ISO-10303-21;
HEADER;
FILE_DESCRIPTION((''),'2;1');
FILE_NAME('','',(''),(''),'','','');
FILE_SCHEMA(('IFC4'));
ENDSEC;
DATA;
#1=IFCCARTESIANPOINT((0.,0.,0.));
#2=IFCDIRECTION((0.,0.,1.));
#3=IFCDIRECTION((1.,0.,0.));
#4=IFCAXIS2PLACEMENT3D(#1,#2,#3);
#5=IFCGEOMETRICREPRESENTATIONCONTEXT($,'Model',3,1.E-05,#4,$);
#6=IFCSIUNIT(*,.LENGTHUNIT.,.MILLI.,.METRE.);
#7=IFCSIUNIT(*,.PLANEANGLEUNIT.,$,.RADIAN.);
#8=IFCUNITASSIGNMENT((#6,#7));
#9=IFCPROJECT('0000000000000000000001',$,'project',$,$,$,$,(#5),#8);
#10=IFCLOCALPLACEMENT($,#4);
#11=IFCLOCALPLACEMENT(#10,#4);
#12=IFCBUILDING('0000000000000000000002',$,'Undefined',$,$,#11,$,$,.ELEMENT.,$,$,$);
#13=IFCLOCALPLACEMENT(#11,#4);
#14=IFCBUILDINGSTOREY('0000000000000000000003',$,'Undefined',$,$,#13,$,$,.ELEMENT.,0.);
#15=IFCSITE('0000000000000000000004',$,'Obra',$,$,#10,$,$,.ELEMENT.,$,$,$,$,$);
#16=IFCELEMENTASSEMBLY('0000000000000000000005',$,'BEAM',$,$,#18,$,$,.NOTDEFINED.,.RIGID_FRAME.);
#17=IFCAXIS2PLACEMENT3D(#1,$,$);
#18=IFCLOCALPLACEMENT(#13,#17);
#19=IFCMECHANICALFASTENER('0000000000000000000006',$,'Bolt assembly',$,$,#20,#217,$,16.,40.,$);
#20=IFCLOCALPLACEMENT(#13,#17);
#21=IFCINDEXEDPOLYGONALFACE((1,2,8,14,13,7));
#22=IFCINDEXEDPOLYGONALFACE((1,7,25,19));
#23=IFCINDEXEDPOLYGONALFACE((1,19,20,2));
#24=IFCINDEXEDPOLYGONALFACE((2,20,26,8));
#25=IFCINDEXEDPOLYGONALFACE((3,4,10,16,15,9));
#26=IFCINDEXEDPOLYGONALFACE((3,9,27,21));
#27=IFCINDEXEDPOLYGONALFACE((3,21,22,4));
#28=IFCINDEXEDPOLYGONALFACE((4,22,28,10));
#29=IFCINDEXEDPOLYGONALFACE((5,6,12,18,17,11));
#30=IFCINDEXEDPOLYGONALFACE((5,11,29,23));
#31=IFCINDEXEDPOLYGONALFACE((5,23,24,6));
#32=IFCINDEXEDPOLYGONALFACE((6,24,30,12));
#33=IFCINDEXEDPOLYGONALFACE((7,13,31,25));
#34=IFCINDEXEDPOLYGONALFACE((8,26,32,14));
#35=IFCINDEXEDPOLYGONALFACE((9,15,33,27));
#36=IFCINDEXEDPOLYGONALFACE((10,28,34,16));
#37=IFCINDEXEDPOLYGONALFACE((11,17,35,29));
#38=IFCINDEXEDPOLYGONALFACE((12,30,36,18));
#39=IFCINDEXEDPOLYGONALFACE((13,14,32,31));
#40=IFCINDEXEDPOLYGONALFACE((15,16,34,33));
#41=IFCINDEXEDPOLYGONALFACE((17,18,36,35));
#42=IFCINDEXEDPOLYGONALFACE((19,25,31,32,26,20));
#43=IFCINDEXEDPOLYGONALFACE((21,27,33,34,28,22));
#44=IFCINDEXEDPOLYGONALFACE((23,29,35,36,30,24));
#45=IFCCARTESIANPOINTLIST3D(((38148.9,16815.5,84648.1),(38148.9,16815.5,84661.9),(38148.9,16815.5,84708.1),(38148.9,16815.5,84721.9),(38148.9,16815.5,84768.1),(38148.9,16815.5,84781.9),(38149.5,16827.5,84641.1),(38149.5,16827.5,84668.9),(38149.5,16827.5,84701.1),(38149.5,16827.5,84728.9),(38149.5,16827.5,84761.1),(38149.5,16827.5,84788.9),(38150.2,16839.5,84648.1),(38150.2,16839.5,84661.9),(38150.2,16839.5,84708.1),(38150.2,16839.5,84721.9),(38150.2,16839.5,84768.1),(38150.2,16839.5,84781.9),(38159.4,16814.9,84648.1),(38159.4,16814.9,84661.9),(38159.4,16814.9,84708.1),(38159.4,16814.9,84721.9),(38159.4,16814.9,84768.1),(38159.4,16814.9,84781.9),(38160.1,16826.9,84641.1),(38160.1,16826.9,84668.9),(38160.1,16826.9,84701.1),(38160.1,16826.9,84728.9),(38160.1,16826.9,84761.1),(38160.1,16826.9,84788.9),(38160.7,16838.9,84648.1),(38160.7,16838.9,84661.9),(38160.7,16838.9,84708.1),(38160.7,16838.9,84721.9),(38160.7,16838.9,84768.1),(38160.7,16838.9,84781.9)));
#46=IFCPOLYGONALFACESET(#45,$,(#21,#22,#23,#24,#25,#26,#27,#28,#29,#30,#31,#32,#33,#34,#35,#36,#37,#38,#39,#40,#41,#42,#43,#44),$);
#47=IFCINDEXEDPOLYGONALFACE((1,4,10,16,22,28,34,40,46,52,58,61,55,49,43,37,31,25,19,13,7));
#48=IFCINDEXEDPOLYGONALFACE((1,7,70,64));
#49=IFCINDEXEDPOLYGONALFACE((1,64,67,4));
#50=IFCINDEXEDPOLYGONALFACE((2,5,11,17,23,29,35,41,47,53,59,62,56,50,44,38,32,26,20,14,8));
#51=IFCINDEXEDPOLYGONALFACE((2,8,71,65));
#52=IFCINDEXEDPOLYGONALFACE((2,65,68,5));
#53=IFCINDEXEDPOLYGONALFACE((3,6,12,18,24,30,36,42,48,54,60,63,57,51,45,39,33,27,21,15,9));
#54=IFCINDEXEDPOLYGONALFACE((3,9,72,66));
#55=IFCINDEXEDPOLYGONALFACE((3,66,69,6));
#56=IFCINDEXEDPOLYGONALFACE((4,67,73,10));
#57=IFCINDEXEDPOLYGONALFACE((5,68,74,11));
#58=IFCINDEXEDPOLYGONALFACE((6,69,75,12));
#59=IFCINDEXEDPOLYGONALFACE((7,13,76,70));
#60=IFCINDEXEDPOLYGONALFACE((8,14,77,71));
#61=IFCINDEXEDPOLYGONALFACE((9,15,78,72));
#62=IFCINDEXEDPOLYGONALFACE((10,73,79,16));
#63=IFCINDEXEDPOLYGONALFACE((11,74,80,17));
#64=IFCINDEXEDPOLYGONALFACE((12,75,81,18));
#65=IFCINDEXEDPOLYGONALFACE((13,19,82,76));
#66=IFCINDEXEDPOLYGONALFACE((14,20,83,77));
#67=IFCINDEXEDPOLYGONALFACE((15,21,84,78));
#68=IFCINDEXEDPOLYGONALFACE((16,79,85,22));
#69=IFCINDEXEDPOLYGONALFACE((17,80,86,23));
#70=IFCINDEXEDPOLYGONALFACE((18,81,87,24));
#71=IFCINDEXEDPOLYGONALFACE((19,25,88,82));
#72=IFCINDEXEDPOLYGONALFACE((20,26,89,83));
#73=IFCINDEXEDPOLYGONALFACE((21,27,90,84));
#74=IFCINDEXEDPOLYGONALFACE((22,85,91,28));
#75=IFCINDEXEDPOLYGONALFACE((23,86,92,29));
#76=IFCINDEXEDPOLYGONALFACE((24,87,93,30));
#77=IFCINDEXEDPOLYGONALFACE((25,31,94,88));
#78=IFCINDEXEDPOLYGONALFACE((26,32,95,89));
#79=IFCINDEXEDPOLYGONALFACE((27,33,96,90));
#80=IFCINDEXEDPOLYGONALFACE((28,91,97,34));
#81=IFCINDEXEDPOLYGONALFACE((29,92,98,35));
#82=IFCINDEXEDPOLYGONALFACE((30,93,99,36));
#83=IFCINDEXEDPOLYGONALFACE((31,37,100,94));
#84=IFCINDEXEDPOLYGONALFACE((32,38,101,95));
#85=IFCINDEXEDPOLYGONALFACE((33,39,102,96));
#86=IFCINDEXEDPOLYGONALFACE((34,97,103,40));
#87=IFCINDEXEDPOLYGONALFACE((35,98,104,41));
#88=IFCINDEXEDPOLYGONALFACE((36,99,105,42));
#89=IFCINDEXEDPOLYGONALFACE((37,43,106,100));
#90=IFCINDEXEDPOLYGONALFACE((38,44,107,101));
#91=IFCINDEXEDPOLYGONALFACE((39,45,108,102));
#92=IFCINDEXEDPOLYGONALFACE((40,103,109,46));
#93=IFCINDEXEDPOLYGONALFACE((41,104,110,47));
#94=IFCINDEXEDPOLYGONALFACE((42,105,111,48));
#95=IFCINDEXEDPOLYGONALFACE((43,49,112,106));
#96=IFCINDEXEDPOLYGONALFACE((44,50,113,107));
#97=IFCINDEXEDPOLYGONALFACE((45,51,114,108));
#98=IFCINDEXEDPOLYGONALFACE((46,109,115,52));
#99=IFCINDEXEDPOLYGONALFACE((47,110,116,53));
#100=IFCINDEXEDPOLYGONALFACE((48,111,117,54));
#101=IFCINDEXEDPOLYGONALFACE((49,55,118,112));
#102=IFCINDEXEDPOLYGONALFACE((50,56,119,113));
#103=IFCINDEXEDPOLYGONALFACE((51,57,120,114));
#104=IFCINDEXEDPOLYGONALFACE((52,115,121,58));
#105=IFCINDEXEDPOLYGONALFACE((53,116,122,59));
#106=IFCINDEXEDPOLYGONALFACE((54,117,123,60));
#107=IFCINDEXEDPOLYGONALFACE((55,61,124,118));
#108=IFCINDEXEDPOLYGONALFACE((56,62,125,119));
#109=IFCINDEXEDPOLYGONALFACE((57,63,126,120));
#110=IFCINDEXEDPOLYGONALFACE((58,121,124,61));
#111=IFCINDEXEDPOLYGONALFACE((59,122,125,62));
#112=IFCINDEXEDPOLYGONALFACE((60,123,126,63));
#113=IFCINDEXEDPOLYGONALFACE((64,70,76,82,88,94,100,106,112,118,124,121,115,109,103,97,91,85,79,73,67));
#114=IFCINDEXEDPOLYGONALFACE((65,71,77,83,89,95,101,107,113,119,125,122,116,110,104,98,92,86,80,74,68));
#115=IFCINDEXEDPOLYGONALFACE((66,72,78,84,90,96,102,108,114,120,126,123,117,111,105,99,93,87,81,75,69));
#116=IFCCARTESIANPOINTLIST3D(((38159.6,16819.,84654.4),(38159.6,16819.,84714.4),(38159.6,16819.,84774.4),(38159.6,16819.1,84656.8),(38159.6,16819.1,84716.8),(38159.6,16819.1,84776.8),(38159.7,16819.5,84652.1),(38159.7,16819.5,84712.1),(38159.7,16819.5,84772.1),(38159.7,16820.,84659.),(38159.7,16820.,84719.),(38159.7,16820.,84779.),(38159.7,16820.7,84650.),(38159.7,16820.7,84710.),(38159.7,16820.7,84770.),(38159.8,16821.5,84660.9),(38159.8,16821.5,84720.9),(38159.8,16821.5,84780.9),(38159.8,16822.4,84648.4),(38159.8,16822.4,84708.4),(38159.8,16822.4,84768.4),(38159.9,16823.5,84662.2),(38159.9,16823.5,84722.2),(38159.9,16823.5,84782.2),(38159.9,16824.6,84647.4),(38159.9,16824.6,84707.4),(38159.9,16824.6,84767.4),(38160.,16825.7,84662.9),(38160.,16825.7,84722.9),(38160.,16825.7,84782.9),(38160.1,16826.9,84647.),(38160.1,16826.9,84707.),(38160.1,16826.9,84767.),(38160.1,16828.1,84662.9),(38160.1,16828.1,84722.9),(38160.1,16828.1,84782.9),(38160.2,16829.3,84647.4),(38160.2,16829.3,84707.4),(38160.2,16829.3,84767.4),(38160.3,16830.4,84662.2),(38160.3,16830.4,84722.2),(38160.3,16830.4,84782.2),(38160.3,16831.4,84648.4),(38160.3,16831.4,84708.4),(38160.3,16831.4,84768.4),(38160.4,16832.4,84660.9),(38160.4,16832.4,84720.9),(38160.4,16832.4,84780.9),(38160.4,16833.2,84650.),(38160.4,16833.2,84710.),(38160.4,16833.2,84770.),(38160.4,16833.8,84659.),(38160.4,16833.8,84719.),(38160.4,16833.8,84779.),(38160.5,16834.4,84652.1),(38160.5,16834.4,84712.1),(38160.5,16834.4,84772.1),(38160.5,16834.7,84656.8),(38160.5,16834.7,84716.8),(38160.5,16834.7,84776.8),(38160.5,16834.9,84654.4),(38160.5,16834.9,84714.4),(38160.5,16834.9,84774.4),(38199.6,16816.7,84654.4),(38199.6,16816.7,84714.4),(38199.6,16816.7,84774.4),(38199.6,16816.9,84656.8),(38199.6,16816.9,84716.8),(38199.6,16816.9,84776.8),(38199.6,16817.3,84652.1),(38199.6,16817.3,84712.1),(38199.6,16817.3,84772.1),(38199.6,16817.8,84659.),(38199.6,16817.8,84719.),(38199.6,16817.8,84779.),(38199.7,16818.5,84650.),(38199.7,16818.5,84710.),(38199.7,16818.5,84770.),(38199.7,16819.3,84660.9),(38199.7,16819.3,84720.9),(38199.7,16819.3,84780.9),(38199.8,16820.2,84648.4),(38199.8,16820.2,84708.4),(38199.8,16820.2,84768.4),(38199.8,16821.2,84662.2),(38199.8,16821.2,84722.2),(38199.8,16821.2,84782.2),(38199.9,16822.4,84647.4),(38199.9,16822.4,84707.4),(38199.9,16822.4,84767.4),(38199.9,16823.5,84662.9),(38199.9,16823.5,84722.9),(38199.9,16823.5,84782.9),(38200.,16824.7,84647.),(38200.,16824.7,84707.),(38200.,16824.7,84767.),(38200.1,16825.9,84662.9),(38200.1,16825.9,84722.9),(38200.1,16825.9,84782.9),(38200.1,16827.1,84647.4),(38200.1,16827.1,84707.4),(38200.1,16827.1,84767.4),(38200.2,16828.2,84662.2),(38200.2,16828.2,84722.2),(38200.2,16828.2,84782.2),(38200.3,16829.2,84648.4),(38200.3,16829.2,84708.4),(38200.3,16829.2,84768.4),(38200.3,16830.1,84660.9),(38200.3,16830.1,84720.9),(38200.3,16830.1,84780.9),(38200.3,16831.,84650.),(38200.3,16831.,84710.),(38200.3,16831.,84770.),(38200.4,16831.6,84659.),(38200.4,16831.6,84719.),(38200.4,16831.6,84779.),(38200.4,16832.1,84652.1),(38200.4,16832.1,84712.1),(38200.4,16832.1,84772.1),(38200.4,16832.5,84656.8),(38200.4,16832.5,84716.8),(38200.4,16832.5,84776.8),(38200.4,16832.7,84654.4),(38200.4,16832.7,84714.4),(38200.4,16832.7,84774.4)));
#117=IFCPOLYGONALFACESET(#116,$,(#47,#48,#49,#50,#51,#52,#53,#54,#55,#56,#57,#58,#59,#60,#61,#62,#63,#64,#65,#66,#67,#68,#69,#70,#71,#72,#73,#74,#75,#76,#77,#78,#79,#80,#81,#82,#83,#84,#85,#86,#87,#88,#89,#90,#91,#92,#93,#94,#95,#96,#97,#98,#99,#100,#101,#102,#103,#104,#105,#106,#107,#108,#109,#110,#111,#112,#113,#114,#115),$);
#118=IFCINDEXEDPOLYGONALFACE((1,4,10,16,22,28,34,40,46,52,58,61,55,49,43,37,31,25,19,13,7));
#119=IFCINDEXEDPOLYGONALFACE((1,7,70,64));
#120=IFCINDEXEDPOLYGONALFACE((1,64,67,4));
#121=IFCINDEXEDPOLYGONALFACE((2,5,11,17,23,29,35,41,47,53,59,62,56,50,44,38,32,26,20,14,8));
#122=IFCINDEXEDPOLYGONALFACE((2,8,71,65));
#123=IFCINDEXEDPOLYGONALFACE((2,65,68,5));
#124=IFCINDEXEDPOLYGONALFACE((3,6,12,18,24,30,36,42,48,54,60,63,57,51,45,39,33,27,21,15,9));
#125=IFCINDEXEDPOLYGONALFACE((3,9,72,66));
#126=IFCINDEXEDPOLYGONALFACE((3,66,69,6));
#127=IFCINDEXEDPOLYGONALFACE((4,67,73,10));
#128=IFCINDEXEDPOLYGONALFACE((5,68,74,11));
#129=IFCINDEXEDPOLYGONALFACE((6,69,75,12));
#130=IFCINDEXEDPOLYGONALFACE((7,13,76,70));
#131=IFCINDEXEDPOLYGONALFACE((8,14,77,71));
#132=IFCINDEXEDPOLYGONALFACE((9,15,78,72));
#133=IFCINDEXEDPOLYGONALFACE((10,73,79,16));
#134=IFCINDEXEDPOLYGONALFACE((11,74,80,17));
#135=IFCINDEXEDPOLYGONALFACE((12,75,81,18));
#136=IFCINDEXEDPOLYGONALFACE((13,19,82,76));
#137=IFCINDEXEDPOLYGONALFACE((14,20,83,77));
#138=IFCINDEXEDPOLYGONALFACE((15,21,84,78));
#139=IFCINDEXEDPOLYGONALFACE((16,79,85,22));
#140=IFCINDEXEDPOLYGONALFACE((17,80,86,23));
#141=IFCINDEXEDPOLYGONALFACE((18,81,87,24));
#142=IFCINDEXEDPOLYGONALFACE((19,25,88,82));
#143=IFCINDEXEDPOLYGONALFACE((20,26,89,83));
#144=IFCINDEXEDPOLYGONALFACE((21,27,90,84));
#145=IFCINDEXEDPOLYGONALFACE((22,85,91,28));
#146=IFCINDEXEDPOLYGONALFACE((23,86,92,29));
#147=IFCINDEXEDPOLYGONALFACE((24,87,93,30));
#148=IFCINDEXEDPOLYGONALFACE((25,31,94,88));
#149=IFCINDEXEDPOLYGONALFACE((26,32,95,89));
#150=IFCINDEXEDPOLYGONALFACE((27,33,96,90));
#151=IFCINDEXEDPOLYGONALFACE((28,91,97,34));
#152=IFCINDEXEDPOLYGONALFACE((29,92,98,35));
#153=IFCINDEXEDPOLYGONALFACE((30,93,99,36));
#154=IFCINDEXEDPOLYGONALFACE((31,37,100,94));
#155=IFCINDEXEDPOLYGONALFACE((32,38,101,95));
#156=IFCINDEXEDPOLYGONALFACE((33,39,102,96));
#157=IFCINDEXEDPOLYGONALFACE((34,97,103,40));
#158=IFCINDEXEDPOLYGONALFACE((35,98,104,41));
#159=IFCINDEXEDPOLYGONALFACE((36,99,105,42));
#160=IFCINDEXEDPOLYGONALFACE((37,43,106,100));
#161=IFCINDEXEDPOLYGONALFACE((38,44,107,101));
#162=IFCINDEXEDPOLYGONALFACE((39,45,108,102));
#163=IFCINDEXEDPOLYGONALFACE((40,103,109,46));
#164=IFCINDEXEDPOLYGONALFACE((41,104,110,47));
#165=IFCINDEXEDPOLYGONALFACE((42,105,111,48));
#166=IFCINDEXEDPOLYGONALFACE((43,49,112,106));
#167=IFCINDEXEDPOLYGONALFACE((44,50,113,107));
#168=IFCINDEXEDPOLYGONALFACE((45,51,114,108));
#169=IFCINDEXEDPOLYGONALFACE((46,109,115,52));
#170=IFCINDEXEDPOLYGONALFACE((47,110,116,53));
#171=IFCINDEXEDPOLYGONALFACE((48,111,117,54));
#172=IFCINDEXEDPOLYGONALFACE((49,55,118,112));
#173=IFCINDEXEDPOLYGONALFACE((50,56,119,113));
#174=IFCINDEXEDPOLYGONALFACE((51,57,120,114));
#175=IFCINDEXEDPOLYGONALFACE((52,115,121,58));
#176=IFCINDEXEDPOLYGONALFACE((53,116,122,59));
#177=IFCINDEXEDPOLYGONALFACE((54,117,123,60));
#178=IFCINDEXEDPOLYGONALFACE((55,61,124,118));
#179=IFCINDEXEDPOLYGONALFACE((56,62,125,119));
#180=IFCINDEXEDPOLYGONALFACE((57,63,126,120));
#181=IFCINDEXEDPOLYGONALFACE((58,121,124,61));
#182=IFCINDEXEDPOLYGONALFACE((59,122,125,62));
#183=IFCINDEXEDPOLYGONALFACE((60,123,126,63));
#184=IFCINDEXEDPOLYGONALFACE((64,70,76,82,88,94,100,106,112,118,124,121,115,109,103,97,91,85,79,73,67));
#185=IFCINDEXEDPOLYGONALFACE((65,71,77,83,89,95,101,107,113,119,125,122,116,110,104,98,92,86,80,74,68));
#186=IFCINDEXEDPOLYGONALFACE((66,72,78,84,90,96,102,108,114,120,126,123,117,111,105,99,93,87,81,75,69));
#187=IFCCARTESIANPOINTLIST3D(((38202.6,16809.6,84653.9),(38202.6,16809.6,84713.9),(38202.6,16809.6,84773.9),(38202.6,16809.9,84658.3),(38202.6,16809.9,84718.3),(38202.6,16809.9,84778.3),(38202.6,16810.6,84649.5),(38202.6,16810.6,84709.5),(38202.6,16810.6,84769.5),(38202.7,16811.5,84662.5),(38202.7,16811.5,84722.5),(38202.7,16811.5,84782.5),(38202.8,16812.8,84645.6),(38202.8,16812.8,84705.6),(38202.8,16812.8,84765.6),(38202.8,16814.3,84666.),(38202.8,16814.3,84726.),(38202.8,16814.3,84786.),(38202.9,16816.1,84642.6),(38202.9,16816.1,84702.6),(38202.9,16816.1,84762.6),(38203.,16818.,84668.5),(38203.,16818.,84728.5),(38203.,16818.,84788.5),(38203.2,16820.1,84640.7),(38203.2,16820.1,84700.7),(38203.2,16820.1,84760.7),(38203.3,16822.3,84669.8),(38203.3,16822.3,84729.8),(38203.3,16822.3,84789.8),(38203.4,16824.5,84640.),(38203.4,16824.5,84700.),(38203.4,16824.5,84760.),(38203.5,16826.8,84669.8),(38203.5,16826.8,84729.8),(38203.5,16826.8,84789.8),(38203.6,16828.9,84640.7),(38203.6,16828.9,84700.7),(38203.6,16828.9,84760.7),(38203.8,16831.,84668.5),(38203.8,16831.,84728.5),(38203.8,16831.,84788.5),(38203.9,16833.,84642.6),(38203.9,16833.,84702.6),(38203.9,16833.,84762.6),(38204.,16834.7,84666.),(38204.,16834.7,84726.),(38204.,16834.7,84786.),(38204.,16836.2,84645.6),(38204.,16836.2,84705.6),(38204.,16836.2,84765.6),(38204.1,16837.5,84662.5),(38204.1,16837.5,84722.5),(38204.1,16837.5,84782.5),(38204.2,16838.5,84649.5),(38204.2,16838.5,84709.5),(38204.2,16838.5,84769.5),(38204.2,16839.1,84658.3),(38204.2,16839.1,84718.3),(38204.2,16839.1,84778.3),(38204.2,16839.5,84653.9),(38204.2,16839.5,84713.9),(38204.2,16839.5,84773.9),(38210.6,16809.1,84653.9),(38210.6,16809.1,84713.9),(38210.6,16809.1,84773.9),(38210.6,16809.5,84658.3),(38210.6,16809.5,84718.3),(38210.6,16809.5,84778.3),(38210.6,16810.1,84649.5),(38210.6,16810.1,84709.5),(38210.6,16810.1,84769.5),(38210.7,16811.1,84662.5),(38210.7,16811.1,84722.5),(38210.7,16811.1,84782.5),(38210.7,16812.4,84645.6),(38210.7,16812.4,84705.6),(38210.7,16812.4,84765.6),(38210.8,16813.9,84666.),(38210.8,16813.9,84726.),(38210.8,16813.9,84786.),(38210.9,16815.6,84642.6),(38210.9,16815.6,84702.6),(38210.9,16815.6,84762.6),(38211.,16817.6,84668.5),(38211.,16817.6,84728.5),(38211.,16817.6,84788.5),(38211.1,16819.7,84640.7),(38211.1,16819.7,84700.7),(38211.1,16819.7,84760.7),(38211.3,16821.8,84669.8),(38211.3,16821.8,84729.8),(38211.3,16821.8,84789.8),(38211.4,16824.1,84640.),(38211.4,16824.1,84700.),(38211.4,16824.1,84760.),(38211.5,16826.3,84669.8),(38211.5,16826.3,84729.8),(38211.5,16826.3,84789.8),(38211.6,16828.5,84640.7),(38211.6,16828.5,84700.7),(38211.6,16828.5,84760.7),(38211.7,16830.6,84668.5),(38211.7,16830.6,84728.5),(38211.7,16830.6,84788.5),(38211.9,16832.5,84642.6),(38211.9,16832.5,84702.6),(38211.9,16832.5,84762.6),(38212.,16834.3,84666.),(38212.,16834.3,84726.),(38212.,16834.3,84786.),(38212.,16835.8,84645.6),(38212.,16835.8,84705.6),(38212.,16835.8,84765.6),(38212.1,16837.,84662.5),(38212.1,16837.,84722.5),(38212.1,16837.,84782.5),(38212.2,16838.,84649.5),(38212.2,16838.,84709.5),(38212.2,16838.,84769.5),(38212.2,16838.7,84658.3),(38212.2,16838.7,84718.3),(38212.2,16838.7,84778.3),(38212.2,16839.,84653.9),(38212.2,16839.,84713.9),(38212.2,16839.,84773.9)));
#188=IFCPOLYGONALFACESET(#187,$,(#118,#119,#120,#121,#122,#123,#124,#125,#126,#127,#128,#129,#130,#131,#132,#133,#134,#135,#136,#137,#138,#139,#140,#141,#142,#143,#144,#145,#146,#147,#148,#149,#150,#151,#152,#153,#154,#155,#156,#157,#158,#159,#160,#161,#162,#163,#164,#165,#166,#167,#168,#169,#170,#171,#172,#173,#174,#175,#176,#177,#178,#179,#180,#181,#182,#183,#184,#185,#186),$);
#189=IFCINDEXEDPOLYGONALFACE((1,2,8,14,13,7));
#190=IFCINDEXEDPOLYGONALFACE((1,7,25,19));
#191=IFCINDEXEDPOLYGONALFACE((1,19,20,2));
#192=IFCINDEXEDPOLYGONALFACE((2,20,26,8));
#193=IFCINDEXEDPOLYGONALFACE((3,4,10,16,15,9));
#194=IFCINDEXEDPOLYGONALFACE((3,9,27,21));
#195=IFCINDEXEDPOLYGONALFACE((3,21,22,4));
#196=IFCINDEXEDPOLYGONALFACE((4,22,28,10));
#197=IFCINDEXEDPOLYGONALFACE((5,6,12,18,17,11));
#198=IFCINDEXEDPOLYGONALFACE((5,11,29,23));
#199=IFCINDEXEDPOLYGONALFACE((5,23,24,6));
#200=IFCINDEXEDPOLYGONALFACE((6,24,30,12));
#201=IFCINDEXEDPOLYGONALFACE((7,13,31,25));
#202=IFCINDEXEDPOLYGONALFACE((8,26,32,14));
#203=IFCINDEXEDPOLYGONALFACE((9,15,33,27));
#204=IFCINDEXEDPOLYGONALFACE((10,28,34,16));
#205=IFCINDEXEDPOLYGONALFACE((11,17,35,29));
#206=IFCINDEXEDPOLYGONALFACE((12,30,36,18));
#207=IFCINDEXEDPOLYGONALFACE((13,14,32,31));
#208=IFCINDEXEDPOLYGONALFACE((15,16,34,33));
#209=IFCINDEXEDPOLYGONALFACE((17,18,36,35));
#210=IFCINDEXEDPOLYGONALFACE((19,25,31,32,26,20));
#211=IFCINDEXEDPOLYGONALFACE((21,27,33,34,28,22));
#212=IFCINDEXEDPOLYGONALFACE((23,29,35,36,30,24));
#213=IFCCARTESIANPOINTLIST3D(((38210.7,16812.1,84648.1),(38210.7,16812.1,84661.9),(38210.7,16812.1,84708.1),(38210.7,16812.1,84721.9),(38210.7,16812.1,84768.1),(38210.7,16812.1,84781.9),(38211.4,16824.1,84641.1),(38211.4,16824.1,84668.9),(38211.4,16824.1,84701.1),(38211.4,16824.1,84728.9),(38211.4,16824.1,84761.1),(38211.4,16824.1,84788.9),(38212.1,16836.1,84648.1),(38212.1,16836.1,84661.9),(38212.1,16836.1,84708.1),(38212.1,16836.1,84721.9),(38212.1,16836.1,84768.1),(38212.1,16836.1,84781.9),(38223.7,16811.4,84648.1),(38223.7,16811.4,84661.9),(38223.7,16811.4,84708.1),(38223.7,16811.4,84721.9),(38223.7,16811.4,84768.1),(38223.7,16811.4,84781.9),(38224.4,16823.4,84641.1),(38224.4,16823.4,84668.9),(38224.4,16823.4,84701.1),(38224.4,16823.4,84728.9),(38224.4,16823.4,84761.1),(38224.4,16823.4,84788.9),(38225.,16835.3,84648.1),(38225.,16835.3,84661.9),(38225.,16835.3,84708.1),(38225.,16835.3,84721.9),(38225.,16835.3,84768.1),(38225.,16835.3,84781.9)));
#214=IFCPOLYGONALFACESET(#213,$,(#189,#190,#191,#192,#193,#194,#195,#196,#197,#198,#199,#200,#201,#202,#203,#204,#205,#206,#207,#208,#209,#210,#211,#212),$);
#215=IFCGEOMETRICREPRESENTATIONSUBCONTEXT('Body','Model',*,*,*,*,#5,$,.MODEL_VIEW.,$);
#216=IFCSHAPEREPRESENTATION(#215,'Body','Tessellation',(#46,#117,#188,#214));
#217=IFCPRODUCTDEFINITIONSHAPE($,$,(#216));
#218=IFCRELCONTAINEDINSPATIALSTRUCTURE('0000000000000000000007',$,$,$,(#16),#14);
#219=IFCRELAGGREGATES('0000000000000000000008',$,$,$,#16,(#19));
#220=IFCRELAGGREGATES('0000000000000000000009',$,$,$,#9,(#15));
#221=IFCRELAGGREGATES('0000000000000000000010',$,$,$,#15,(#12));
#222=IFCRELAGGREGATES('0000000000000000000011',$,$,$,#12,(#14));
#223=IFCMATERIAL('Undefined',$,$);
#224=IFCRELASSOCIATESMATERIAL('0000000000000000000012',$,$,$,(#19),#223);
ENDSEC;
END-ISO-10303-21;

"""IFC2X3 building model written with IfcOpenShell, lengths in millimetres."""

from ifc_helpers import new_model, si_unit, frame, origin_with_axes, origin_2d_with_axis, place, context, subcontext, project, spatial, polyline, circle, outline, extrude, source, transform, mapped, material, element, aggregate, save


model = new_model("IFC2X3")

# Units and contexts
model_context = context("Model", 3, precision=1e-05, world=origin_with_axes())
body_context = subcontext(model_context, "Body", "Model", "MODEL_VIEW")
ifc_project = project(units=[si_unit("LENGTHUNIT", "METRE", prefix="MILLI"), si_unit("PLANEANGLEUNIT", "RADIAN")], contexts=[model_context])

# Site, building, storey
site_placement = place(None, origin_with_axes())
site = spatial("IfcSite", under=ifc_project, at=site_placement, Name="Obra", CompositionType="ELEMENT")
building_placement = place(site_placement, origin_with_axes())
building = spatial("IfcBuilding", under=site, at=building_placement, Name="Undefined", CompositionType="ELEMENT")
storey_placement = place(building_placement, origin_with_axes())
storey = spatial("IfcBuildingStorey", under=building, at=storey_placement, Name="Undefined", CompositionType="ELEMENT", Elevation=0.0)

# Element assembly, mechanical fastener
ifc_material_1 = material(Name="Undefined")
shared_shape_1 = source(origin_with_axes(), body_context, "Body", "SweptSolid", [
    extrude(outline(polyline([(13.9, 0.0), (6.9, 12.0), (-6.9, 12.0), (-13.9, 0.0), (-6.9, -12.0), (6.9, -12.0), (13.9, 0.0)])), frame((0.0, -19.7, 0.0), z_axis=(0.0, 1.0, 0.0), x_axis=(1.0, 0.0, 0.0)), (0.0, 0.0, 1.0), 10.6),
    extrude(circle(Radius=8.0, at=origin_2d_with_axis()), frame((0.0, -9.1, 0.0), z_axis=(0.0, 1.0, 0.0), x_axis=(1.0, 0.0, 0.0)), (0.0, 0.0, 1.0), 40.0),
    extrude(circle(Radius=15.0, at=origin_2d_with_axis()), frame((0.0, 34.3, 0.0), z_axis=(0.0, 1.0, 0.0), x_axis=(1.0, 0.0, 0.0)), (0.0, 0.0, 1.0), 8.0),
    extrude(outline(polyline([(13.9, 0.0), (6.9, 12.0), (-6.9, 12.0), (-13.9, 0.0), (-6.9, -12.0), (6.9, -12.0), (13.9, 0.0)])), frame((0.0, 42.3, 0.0), z_axis=(0.0, 1.0, 0.0), x_axis=(1.0, 0.0, 0.0)), (0.0, 0.0, 1.0), 13.0),
])
assembly_1_placement = place(storey_placement, origin_with_axes())
assembly_1 = element("IfcElementAssembly", 1, at=assembly_1_placement, inside=storey, Name="BEAM", AssemblyPlace="NOTDEFINED", PredefinedType="RIGID_FRAME")
mechanical_fastener_1_placement = place(assembly_1_placement, frame((38171.9, 16876.3, 84835.0), z_axis=(-0.055268, -0.998472, 0.0), x_axis=(0.0, 0.0, -1.0)))
mechanical_fastener_1 = element("IfcMechanicalFastener", 2, at=mechanical_fastener_1_placement, material=ifc_material_1, Name="Bolt assembly", NominalDiameter=16.0, NominalLength=40.0, context=body_context, shape_type="MappedRepresentation", body=[
    mapped(shared_shape_1, transform((60.0, 0.0, 50.0))),
    mapped(shared_shape_1, transform((120.0, 0.0, 50.0))),
    mapped(shared_shape_1, transform((180.0, 0.0, 50.0))),
])
aggregate(assembly_1, [mechanical_fastener_1])

save(model, "model.ifc")
